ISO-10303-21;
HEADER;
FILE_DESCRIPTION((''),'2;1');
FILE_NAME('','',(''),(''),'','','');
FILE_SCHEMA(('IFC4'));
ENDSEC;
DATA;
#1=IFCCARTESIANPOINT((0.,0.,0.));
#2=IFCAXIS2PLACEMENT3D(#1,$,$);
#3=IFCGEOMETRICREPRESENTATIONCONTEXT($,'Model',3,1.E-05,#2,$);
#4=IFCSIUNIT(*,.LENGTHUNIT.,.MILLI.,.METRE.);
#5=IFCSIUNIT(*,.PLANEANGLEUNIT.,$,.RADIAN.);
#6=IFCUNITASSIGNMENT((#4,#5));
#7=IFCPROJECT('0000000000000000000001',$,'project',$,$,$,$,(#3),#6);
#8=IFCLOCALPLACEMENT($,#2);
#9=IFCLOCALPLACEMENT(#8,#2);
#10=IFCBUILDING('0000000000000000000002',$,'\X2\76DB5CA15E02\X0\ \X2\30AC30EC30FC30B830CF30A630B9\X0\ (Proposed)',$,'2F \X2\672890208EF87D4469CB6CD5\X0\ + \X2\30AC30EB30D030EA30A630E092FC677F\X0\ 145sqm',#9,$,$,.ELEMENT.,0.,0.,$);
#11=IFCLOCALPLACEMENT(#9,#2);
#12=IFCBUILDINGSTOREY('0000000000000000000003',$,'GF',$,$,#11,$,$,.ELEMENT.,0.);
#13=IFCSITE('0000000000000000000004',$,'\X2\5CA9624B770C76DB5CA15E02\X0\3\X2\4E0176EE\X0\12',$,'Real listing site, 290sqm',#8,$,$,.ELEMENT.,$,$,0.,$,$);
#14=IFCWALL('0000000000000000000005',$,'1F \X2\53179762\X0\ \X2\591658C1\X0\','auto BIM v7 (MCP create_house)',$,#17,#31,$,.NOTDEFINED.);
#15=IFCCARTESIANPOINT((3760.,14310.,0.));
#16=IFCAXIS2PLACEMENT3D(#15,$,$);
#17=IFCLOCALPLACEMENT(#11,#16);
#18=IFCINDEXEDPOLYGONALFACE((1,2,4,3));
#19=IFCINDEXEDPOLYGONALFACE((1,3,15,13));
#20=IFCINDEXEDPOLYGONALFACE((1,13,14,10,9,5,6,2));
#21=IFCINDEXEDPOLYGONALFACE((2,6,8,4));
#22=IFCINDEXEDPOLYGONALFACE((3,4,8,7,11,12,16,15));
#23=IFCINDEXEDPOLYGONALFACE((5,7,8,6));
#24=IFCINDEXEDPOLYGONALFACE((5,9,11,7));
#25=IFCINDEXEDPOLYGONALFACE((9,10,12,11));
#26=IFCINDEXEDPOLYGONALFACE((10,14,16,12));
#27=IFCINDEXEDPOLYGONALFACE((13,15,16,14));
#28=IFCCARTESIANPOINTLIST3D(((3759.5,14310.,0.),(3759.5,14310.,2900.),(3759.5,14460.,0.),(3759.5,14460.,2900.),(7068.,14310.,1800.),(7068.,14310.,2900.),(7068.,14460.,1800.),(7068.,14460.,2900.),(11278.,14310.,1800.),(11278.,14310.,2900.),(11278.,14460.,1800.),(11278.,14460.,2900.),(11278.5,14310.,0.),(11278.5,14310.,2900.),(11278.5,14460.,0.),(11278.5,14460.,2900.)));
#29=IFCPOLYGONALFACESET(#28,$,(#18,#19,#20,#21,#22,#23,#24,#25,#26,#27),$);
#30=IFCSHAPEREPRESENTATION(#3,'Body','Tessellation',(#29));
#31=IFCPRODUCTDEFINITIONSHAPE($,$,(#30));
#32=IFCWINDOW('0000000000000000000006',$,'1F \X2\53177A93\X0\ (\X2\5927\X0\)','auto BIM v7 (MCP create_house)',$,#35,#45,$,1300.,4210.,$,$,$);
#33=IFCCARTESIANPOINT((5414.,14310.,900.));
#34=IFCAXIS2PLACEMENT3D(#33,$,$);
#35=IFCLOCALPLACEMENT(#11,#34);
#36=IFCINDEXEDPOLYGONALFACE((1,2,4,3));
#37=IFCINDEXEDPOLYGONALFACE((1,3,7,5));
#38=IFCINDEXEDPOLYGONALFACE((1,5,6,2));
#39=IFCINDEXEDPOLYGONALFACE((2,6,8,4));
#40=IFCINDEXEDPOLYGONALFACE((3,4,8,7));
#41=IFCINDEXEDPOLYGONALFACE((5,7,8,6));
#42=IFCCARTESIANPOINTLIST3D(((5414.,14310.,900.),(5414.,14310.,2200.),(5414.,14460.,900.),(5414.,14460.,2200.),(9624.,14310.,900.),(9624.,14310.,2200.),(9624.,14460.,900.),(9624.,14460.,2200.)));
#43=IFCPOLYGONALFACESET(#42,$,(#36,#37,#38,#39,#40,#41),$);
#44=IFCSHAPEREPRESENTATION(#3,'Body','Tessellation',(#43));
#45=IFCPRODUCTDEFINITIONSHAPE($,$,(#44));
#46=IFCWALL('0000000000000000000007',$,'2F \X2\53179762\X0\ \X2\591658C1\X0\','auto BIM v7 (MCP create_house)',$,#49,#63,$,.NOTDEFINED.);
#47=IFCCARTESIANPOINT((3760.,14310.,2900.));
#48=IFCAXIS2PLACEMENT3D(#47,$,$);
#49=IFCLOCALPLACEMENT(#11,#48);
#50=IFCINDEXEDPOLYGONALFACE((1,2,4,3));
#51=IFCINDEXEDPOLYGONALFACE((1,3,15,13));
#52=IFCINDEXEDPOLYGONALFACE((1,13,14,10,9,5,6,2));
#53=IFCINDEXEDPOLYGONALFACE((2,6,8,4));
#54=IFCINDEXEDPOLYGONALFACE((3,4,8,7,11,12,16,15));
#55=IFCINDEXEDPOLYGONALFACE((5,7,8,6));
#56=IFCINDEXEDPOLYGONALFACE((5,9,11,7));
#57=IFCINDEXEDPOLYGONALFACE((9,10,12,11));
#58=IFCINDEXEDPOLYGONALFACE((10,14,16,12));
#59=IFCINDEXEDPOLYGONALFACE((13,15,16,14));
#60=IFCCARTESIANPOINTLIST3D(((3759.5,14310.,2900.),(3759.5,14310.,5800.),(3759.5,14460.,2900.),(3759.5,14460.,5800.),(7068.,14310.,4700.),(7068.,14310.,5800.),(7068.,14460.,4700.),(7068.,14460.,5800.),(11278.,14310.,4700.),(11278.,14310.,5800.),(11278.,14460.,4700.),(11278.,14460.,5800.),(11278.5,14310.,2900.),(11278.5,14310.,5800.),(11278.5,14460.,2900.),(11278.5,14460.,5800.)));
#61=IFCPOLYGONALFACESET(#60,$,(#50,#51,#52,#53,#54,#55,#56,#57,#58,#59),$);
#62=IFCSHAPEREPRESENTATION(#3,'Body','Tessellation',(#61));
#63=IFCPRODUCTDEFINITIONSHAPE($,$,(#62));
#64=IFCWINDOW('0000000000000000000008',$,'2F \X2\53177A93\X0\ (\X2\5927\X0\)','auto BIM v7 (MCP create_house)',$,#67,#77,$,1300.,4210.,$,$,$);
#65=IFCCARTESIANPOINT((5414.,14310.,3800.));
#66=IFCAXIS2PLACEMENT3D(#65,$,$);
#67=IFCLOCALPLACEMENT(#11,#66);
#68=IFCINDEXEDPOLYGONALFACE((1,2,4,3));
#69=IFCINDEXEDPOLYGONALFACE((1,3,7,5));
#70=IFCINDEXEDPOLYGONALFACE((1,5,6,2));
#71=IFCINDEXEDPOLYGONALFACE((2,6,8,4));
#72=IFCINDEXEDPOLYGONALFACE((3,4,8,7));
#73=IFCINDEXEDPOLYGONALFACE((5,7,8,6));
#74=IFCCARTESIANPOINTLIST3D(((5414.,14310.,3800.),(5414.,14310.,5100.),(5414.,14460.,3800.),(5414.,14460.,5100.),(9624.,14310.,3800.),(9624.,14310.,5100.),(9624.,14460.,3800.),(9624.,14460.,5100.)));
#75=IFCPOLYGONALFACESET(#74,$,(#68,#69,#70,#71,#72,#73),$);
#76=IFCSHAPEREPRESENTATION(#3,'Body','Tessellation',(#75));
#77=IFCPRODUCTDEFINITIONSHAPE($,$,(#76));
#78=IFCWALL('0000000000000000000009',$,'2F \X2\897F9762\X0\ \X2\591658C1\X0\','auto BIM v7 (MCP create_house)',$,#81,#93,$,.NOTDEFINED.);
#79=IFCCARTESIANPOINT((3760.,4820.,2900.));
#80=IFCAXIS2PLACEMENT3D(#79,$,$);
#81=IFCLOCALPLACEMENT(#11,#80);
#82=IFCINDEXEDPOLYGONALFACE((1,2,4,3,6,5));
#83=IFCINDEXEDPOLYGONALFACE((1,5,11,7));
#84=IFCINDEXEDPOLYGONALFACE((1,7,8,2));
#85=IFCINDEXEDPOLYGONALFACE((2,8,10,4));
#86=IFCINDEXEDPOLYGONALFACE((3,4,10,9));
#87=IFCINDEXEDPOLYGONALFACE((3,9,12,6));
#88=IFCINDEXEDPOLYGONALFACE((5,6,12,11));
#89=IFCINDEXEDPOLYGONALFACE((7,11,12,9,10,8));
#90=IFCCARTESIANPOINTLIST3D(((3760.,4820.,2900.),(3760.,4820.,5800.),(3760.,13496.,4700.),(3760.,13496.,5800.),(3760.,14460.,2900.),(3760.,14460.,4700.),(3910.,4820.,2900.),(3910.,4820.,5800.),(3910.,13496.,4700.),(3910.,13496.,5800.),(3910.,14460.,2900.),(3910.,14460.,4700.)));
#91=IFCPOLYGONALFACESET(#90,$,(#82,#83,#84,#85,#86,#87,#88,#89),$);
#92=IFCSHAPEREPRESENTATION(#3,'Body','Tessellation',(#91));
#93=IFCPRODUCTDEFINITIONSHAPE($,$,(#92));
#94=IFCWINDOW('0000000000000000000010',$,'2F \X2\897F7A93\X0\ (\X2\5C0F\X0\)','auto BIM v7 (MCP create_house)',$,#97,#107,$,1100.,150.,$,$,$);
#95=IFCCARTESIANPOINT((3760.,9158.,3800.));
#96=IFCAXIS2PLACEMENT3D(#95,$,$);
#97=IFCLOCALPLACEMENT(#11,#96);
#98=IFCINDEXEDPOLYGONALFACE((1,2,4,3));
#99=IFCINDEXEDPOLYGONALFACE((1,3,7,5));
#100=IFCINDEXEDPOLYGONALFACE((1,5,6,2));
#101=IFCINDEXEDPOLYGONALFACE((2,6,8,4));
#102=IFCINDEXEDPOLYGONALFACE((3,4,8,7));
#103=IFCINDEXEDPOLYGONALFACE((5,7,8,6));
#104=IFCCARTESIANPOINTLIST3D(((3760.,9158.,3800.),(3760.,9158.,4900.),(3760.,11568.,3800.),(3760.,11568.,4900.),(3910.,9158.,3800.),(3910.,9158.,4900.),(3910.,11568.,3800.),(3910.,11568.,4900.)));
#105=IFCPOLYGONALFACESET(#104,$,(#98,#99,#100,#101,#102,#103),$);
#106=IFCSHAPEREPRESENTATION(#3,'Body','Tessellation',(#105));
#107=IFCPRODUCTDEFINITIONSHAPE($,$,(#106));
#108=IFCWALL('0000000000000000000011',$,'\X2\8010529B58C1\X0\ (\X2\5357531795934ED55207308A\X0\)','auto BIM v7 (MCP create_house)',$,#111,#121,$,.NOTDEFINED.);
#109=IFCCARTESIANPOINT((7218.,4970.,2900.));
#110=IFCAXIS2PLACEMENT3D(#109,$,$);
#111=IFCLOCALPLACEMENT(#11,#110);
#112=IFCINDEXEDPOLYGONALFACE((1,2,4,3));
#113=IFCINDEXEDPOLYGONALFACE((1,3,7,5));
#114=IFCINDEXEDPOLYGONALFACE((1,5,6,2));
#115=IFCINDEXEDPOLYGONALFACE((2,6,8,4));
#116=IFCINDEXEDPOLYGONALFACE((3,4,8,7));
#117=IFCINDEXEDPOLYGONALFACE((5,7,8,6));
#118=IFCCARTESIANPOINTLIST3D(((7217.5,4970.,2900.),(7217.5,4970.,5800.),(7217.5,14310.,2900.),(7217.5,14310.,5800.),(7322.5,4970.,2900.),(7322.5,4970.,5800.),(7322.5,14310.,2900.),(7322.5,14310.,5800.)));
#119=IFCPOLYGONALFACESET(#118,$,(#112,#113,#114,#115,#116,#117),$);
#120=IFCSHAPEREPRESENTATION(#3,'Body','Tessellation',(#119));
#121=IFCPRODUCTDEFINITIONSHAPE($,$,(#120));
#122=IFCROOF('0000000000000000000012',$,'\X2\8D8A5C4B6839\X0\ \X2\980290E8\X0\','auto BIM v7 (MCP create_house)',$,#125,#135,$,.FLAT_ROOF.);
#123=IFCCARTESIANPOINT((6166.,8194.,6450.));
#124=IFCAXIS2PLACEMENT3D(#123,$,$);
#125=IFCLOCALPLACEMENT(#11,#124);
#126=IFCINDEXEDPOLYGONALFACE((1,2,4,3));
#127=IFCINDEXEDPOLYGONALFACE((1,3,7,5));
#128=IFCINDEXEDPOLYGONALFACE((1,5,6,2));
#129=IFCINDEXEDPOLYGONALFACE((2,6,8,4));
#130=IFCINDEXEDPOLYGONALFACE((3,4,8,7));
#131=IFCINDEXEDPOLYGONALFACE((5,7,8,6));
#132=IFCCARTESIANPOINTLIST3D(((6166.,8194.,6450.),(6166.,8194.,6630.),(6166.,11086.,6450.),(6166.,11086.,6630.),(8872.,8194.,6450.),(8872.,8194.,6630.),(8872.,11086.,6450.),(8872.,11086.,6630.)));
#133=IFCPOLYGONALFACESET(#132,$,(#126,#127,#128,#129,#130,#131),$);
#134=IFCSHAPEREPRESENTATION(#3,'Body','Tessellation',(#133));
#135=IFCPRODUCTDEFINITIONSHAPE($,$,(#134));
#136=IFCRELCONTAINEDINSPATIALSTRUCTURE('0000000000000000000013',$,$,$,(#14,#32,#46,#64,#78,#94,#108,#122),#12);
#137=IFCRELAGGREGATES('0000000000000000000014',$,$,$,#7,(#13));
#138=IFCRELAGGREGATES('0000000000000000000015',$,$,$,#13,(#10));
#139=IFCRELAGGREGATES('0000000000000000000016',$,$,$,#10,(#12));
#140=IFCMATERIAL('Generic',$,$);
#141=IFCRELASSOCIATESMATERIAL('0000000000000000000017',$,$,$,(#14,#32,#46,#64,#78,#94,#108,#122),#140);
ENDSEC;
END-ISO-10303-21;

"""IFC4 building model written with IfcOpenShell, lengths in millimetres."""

from ifc_helpers import new_model, si_unit, frame, frame_2d, origin, place, context, project, spatial, rectangle, extrude, material, element, fill, save


model = new_model("IFC4")

# Units and contexts
model_context = context("Model", 3, precision=1e-05, world=origin())
ifc_project = project(units=[si_unit("LENGTHUNIT", "METRE", prefix="MILLI"), si_unit("PLANEANGLEUNIT", "RADIAN")], contexts=[model_context])

# Site, building, storey
site_placement = place(None, origin())
site = spatial("IfcSite", under=ifc_project, at=site_placement, Name="岩手県盛岡市3丁目12", ObjectType="Real listing site, 290sqm", CompositionType="ELEMENT", RefElevation=0.0)
building_placement = place(site_placement, origin())
building = spatial("IfcBuilding", under=site, at=building_placement, Name="盛岡市 ガレージハウス (Proposed)", ObjectType="2F 木造軸組構法 + ガルバリウム鋼板 145sqm", CompositionType="ELEMENT", ElevationOfRefHeight=0.0, ElevationOfTerrain=0.0)
storey_placement = place(building_placement, origin())
storey = spatial("IfcBuildingStorey", under=building, at=storey_placement, Name="GF", CompositionType="ELEMENT", Elevation=0.0)

# Wall, opening, window
ifc_material = material(Name="Generic")
wall_1_placement = place(storey_placement, frame((3760.0, 14310.0, 0.0)))
wall_1 = element("IfcWall", 1, at=wall_1_placement, inside=storey, material=ifc_material, Name="1F 北面 外壁", Description="auto BIM v7 (MCP create_house)", PredefinedType="NOTDEFINED", context=model_context, shape_type="SweptSolid", body=[
    extrude(rectangle(XDim=7519.0, YDim=150.0, at=frame_2d((3759.0, 75.0))), frame((3760.0, 14310.0, 0.0)), (0.0, 0.0, 1.0), 2900.0),
])
opening_1_placement = place(storey_placement, frame((5414.0, 14310.0, 900.0)))
opening_1 = element("IfcOpeningElement", 2, at=opening_1_placement, cuts=wall_1, PredefinedType="NOTDEFINED", context=model_context, shape_type="SweptSolid", body=[
    extrude(rectangle(XDim=4210.0, YDim=150.0, at=frame_2d((2105.0, 75.0))), frame((5414.0, 14310.0, 900.0)), (0.0, 0.0, 1.0), 1300.0),
])
window_1_placement = place(storey_placement, frame((5414.0, 14310.0, 900.0)))
window_1 = element("IfcWindow", 3, at=window_1_placement, inside=storey, material=ifc_material, Name="1F 北窓 (大)", Description="auto BIM v7 (MCP create_house)", OverallHeight=1300.0, OverallWidth=4210.0, context=model_context, shape_type="SweptSolid", body=[
    extrude(rectangle(XDim=4210.0, YDim=150.0, at=frame_2d((2105.0, 75.0))), frame((5414.0, 14310.0, 900.0)), (0.0, 0.0, 1.0), 1300.0),
])
fill(opening_1, window_1)

# Walls, openings, windows
wall_2_placement = place(storey_placement, frame((3760.0, 14310.0, 2900.0)))
wall_2 = element("IfcWall", 4, at=wall_2_placement, inside=storey, material=ifc_material, Name="2F 北面 外壁", Description="auto BIM v7 (MCP create_house)", PredefinedType="NOTDEFINED", context=model_context, shape_type="SweptSolid", body=[
    extrude(rectangle(XDim=7519.0, YDim=150.0, at=frame_2d((3759.0, 75.0))), frame((3760.0, 14310.0, 2900.0)), (0.0, 0.0, 1.0), 2900.0),
])
opening_2_placement = place(storey_placement, frame((5414.0, 14310.0, 3800.0)))
opening_2 = element("IfcOpeningElement", 5, at=opening_2_placement, cuts=wall_2, PredefinedType="NOTDEFINED", context=model_context, shape_type="SweptSolid", body=[
    extrude(rectangle(XDim=4210.0, YDim=150.0, at=frame_2d((2105.0, 75.0))), frame((5414.0, 14310.0, 3800.0)), (0.0, 0.0, 1.0), 1300.0),
])
window_2_placement = place(storey_placement, frame((5414.0, 14310.0, 3800.0)))
window_2 = element("IfcWindow", 6, at=window_2_placement, inside=storey, material=ifc_material, Name="2F 北窓 (大)", Description="auto BIM v7 (MCP create_house)", OverallHeight=1300.0, OverallWidth=4210.0, context=model_context, shape_type="SweptSolid", body=[
    extrude(rectangle(XDim=4210.0, YDim=150.0, at=frame_2d((2105.0, 75.0))), frame((5414.0, 14310.0, 3800.0)), (0.0, 0.0, 1.0), 1300.0),
])
fill(opening_2, window_2)
wall_3_placement = place(storey_placement, frame((3760.0, 4820.0, 2900.0)))
wall_3 = element("IfcWall", 7, at=wall_3_placement, inside=storey, material=ifc_material, Name="2F 西面 外壁", Description="auto BIM v7 (MCP create_house)", PredefinedType="NOTDEFINED", context=model_context, shape_type="SweptSolid", body=[
    extrude(rectangle(XDim=150.0, YDim=9640.0, at=frame_2d((75.0, 4820.0))), frame((3760.0, 4820.0, 2900.0)), (0.0, 0.0, 1.0), 2900.0),
])
opening_3_placement = place(storey_placement, frame((3760.0, 9158.0, 3800.0)))
opening_3 = element("IfcOpeningElement", 8, at=opening_3_placement, cuts=wall_3, PredefinedType="NOTDEFINED", context=model_context, shape_type="SweptSolid", body=[
    extrude(rectangle(XDim=150.0, YDim=2410.0, at=frame_2d((75.0, 1205.0))), frame((3760.0, 9158.0, 3800.0)), (0.0, 0.0, 1.0), 1100.0),
])
window_3_placement = place(storey_placement, frame((3760.0, 9158.0, 3800.0)))
window_3 = element("IfcWindow", 9, at=window_3_placement, inside=storey, material=ifc_material, Name="2F 西窓 (小)", Description="auto BIM v7 (MCP create_house)", OverallHeight=1100.0, OverallWidth=150.0, context=model_context, shape_type="SweptSolid", body=[
    extrude(rectangle(XDim=150.0, YDim=2410.0, at=frame_2d((75.0, 1205.0))), frame((3760.0, 9158.0, 3800.0)), (0.0, 0.0, 1.0), 1100.0),
])
fill(opening_3, window_3)

# Wall
wall_4_placement = place(storey_placement, frame((7218.0, 4970.0, 2900.0)))
element("IfcWall", 10, at=wall_4_placement, inside=storey, material=ifc_material, Name="耐力壁 (南北間仕切り)", Description="auto BIM v7 (MCP create_house)", PredefinedType="NOTDEFINED", context=model_context, shape_type="SweptSolid", body=[
    extrude(rectangle(XDim=105.0, YDim=9340.0, at=frame_2d((52.0, 4670.0))), frame((7218.0, 4970.0, 2900.0)), (0.0, 0.0, 1.0), 2900.0),
])

# Roof
roof_placement = place(storey_placement, frame((6166.0, 8194.0, 6450.0)))
element("IfcRoof", 11, at=roof_placement, inside=storey, material=ifc_material, Name="越屋根 頂部", Description="auto BIM v7 (MCP create_house)", PredefinedType="FLAT_ROOF", context=model_context, shape_type="SweptSolid", body=[
    extrude(rectangle(XDim=2706.0, YDim=2892.0, at=frame_2d((1353.0, 1446.0))), frame((6166.0, 8194.0, 6450.0)), (0.0, 0.0, 1.0), 180.0),
])

save(model, "model.ifc")
